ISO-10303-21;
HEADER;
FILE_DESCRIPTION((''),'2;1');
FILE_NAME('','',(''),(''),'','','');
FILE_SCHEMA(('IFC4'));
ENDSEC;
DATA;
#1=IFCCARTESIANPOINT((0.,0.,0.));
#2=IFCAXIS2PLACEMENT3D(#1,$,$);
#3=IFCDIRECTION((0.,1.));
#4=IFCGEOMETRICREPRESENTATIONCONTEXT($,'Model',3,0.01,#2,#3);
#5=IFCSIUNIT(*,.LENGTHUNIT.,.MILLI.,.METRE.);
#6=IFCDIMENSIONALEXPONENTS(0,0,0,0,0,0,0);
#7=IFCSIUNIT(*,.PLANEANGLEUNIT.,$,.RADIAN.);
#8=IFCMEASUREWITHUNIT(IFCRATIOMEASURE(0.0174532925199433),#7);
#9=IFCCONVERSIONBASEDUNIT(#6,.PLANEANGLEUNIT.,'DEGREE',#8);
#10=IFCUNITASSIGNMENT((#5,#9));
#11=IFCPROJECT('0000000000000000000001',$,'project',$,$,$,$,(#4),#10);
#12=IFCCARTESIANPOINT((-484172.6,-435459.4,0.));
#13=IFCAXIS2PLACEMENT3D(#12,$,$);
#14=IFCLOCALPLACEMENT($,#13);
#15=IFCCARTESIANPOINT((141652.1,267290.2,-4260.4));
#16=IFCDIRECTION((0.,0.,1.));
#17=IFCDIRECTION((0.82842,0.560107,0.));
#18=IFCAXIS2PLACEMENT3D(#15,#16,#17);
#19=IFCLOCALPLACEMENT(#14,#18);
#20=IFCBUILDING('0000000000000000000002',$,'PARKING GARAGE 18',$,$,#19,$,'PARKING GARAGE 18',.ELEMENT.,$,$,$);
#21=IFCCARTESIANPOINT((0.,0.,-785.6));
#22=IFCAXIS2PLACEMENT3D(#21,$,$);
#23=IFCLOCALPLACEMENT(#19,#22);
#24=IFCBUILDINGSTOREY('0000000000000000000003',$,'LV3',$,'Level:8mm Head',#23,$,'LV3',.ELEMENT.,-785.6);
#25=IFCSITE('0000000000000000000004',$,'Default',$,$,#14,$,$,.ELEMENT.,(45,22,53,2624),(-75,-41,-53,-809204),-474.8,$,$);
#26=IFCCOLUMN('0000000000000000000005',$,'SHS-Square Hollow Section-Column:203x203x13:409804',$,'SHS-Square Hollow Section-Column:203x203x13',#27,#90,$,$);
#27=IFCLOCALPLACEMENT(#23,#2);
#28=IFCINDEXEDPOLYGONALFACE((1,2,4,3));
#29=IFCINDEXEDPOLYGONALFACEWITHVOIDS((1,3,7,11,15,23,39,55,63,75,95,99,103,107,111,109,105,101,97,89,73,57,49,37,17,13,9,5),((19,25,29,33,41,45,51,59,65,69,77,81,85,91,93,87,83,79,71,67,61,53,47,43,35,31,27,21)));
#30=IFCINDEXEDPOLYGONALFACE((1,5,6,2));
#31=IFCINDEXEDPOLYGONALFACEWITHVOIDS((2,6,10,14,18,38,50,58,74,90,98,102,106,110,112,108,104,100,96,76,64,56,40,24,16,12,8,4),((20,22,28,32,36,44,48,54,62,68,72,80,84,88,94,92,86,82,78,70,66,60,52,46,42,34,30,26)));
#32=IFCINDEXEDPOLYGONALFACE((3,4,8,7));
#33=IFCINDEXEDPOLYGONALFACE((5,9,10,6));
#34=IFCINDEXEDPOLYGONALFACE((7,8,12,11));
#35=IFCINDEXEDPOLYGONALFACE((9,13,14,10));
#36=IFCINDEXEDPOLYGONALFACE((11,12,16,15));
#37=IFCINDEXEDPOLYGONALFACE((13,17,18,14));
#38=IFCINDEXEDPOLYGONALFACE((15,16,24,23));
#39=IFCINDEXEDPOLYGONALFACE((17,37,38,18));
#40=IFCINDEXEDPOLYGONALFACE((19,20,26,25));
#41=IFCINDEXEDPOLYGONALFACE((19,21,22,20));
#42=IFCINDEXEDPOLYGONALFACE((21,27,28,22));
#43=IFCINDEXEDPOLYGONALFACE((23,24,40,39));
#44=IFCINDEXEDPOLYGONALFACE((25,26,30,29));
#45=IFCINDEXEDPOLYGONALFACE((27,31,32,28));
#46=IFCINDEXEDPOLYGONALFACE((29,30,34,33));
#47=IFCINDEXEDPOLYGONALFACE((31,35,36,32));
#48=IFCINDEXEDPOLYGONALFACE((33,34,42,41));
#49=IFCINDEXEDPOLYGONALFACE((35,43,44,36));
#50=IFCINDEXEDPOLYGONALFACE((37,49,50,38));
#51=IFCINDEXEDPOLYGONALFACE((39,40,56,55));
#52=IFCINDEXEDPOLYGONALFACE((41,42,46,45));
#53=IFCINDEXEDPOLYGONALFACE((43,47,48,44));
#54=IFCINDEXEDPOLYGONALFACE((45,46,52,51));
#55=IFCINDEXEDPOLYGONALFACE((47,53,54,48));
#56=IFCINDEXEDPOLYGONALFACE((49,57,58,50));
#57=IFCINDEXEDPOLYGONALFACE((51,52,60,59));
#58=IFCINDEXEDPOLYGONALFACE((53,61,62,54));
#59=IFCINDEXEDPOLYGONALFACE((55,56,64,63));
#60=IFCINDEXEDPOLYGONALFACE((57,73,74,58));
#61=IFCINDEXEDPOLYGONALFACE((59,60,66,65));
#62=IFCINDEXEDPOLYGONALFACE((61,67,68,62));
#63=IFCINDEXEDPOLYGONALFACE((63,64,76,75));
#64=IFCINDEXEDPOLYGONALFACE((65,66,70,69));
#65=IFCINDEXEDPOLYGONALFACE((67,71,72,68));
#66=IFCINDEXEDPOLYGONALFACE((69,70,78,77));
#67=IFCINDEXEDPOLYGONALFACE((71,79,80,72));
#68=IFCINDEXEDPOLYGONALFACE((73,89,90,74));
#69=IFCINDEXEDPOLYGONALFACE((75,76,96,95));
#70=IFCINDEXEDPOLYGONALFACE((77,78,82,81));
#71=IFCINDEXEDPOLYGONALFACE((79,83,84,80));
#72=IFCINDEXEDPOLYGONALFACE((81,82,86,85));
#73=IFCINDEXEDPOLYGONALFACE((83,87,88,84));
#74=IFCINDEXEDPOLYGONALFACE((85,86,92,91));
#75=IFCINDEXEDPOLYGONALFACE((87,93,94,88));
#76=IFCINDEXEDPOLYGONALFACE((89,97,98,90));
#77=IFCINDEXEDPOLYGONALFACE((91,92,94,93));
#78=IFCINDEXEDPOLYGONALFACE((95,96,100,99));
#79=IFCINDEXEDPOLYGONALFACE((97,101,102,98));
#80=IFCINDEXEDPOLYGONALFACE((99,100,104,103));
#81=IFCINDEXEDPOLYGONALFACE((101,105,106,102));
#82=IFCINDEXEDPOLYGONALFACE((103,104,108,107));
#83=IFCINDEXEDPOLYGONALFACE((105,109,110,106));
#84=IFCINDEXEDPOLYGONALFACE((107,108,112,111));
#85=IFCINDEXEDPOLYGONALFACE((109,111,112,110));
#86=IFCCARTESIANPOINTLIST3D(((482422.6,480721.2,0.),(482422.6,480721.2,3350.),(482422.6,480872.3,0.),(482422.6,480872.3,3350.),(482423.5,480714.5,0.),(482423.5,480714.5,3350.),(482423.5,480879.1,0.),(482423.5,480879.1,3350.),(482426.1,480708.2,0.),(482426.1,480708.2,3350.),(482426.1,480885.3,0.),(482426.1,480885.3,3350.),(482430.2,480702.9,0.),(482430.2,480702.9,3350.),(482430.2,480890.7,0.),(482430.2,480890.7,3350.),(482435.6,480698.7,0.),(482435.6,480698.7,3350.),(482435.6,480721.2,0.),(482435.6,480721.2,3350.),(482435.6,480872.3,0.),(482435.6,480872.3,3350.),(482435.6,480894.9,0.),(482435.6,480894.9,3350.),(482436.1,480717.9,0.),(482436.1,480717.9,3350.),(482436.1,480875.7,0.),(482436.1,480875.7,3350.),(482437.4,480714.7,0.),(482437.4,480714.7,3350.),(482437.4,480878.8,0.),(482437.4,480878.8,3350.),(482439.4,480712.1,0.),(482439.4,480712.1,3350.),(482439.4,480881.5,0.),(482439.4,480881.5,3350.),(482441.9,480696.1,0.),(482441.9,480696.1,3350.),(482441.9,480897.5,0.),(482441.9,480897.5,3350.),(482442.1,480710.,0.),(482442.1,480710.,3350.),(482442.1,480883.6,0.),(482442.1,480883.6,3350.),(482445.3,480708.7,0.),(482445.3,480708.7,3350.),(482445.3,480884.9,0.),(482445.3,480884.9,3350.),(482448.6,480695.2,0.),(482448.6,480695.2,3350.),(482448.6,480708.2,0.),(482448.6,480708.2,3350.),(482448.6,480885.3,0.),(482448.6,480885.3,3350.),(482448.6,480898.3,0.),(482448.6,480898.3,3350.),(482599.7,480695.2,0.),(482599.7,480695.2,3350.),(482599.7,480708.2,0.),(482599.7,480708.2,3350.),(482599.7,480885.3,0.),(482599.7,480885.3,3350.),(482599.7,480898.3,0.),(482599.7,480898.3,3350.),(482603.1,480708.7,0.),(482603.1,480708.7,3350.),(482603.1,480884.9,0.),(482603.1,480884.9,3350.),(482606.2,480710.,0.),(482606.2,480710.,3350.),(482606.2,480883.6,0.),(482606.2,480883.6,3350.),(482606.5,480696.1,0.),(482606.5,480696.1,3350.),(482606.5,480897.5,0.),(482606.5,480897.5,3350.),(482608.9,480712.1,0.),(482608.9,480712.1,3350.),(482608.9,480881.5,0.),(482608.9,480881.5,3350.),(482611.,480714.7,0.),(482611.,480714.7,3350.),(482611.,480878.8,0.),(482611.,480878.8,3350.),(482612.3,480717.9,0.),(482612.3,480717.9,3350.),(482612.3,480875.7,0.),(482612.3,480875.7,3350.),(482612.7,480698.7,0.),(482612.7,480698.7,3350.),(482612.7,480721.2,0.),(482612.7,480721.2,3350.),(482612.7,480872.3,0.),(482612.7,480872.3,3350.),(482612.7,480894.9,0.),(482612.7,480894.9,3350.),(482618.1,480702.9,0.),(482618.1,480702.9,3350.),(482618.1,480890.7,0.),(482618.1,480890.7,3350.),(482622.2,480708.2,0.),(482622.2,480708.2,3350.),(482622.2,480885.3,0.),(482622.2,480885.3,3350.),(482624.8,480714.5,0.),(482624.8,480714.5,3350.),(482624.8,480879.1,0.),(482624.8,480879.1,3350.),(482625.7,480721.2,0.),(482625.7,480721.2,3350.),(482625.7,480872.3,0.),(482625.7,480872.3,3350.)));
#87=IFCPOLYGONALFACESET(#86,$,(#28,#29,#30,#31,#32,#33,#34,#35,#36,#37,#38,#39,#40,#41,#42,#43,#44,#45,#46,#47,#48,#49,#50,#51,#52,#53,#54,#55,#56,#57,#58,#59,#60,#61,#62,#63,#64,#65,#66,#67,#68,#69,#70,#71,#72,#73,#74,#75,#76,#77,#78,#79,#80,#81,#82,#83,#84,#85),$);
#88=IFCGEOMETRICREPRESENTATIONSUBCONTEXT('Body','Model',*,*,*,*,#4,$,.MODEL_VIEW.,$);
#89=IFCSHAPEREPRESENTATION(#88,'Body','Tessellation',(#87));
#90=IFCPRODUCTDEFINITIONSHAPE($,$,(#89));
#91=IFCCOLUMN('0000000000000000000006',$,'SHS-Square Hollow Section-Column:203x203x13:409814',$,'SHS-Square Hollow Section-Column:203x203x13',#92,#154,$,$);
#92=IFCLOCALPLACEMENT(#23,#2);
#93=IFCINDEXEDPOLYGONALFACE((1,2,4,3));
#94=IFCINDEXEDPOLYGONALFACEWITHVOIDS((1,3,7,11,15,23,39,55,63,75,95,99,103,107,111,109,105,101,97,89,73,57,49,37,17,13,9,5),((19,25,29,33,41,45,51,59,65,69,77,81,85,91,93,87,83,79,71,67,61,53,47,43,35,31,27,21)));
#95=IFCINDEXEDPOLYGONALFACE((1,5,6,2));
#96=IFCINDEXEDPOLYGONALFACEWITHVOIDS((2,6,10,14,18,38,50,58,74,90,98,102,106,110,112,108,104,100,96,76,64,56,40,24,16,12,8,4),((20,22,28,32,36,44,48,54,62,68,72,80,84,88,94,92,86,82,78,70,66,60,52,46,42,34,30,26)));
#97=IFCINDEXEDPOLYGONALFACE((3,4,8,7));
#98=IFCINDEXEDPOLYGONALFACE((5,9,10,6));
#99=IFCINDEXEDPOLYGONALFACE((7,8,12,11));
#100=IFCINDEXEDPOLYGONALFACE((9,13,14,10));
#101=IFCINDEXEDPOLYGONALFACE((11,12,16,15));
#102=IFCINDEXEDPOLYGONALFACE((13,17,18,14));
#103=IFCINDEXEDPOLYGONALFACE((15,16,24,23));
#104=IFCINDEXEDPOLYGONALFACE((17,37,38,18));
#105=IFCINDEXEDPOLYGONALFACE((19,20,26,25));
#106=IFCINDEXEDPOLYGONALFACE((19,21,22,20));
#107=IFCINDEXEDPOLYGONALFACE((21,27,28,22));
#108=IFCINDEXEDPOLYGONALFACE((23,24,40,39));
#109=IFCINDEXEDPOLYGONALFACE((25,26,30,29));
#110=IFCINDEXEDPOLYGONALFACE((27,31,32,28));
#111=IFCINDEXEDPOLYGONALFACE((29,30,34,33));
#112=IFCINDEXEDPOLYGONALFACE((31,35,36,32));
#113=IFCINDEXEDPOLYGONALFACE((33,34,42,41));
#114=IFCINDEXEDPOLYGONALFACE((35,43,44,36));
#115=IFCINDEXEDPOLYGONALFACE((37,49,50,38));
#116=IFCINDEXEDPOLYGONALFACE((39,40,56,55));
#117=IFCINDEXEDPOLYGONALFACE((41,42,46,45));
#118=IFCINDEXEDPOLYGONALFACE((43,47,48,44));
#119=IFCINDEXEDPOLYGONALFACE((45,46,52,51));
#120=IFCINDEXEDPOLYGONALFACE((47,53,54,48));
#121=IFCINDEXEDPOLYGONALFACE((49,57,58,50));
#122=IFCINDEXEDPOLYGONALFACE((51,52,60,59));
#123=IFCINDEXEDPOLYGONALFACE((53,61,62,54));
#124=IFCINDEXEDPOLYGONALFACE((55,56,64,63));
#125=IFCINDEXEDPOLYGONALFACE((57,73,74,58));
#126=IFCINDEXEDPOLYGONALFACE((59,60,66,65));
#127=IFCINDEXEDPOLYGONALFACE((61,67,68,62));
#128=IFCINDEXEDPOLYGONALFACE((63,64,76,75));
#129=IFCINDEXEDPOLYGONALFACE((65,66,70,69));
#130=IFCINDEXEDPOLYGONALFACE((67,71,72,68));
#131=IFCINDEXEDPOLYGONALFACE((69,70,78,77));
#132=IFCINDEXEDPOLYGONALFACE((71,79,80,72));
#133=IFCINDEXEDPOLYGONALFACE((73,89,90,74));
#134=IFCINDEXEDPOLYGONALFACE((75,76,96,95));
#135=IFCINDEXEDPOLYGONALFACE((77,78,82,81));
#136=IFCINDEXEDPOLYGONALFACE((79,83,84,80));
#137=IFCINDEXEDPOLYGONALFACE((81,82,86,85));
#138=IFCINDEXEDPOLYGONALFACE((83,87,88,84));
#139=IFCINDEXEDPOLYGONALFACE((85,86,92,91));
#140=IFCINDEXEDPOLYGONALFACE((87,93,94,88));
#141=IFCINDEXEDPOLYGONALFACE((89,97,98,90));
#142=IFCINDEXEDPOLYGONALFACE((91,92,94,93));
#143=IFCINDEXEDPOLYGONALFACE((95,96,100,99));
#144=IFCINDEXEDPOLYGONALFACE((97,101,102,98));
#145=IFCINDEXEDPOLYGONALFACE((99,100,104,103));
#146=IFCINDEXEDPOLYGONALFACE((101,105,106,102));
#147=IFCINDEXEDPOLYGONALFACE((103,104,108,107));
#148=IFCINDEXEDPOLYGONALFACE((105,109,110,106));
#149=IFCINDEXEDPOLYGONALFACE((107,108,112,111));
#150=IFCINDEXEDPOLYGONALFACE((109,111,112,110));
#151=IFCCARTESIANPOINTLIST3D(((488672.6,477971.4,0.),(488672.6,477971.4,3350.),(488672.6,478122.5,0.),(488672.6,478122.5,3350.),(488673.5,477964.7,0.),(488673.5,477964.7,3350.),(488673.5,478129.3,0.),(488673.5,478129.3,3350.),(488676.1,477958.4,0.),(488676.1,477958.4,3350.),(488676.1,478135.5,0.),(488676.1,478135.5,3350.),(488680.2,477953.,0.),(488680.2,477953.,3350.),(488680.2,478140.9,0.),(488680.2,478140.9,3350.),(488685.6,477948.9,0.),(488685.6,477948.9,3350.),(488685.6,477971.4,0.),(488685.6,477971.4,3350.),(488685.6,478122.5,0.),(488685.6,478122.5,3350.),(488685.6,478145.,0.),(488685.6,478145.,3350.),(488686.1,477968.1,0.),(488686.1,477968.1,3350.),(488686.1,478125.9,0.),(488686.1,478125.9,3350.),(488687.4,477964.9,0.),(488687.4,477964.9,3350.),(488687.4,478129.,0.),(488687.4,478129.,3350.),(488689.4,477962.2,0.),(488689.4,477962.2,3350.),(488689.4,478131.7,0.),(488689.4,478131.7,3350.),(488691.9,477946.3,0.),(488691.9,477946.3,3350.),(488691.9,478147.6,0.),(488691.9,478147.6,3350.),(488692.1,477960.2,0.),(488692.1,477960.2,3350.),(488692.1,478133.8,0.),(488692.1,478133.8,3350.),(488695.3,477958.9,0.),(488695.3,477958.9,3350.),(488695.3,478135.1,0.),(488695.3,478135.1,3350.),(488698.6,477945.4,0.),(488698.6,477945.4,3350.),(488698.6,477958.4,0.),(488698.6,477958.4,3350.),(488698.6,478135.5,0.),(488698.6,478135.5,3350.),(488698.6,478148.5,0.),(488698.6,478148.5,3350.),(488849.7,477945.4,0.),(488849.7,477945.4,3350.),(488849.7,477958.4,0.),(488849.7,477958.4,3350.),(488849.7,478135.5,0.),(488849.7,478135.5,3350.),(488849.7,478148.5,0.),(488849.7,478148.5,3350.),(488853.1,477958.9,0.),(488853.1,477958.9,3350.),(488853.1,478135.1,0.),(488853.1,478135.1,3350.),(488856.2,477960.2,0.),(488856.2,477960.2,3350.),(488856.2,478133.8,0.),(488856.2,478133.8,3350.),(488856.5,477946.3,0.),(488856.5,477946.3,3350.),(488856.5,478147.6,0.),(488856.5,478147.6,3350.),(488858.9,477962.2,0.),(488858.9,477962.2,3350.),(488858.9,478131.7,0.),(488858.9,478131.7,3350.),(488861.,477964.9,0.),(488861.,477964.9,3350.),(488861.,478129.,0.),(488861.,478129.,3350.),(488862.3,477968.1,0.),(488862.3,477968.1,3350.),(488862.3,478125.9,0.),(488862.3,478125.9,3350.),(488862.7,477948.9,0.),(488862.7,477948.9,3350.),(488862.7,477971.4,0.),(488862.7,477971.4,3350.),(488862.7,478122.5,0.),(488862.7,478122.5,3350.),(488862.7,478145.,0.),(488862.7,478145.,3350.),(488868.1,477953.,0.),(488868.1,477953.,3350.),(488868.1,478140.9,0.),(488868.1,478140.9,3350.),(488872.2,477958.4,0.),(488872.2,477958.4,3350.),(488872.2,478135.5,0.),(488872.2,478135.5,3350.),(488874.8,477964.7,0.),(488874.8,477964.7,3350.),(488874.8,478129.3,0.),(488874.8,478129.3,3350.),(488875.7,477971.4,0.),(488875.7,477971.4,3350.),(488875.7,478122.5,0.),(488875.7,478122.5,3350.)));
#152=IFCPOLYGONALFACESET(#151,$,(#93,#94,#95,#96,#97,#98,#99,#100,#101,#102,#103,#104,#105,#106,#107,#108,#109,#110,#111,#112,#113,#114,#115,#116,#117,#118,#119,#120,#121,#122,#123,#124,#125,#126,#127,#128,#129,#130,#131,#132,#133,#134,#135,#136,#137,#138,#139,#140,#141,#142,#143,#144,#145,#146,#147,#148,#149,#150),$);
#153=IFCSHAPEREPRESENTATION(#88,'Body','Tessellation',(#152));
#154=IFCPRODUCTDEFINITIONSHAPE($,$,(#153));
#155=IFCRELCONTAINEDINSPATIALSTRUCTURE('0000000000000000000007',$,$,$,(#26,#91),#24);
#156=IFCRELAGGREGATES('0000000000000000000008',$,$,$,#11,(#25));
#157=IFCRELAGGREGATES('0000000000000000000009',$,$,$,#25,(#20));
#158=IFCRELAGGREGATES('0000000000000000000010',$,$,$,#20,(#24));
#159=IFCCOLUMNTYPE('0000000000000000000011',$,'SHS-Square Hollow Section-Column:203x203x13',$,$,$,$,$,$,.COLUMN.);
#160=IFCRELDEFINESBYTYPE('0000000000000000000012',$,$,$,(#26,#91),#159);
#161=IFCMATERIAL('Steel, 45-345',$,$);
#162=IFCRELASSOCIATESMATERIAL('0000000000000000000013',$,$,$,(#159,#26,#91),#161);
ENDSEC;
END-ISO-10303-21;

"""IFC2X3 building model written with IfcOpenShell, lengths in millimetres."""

from ifc_helpers import new_model, entity, si_unit, converted_unit, direction, frame, frame_2d, origin, place, context, subcontext, project, spatial, polyline, circle_curve, parameter, trimmed, segment, composite_curve, outline, extrude, source, transform, mapped, material, type_object, type_shapes, element, save


model = new_model("IFC2X3")

# Units and contexts
model_context = context("Model", 3, precision=0.01, world=origin(), true_north=direction((0.0, 1.0)))
body_context = subcontext(model_context, "Body", "Model", "MODEL_VIEW")
ifc_project = project(units=[si_unit("LENGTHUNIT", "METRE", prefix="MILLI"), converted_unit("PLANEANGLEUNIT", "DEGREE", entity("IfcRatioMeasure", 0.0174532925199433), si_unit("PLANEANGLEUNIT", "RADIAN"), dimensions=[0, 0, 0, 0, 0, 0, 0])], contexts=[model_context])

# Site, building, storey
site_placement = place(None, frame((-484172.6, -435459.4, 0.0)))
site = spatial("IfcSite", under=ifc_project, at=site_placement, Name="Default", CompositionType="ELEMENT", RefLatitude=(45, 22, 53, 2624), RefLongitude=(-75, -41, -53, -809204), RefElevation=-474.8)
building_placement = place(site_placement, frame((141652.1, 267290.2, -4260.4), z_axis=(0.0, 0.0, 1.0), x_axis=(0.82842, 0.560107, 0.0)))
building = spatial("IfcBuilding", under=site, at=building_placement, Name="PARKING GARAGE 18", LongName="PARKING GARAGE 18", CompositionType="ELEMENT")
storey_placement = place(building_placement, frame((0.0, 0.0, -785.6)))
storey = spatial("IfcBuildingStorey", under=building, at=storey_placement, Name="LV3", ObjectType="Level:8mm Head", LongName="LV3", CompositionType="ELEMENT", Elevation=-785.6)

# Columns
ifc_material_1 = material(Name="Steel, 45-345")
column_type_1 = type_object("IfcColumnType", Name="SHS-Square Hollow Section-Column:203x203x13", PredefinedType="COLUMN", material=ifc_material_1)
shared_shape_1 = source(origin(), body_context, "Body", "SweptSolid", [
    extrude(outline(composite_curve([segment(polyline([(-75.6, -101.5), (75.6, -101.5)]), True, "CONTINUOUS"), segment(trimmed(circle_curve(frame_2d((75.6, -75.6), x_axis=(-1.0, 0.0)), 26.0), [parameter(90.0)], [parameter(180.0)], True, "PARAMETER"), True, "CONTINUOUS"), segment(polyline([(101.5, -75.6), (101.5, 75.6)]), True, "CONTINUOUS"), segment(trimmed(circle_curve(frame_2d((75.5, 75.6), x_axis=(-1.0, 0.0)), 26.0), [parameter(180.0)], [parameter(270.0)], True, "PARAMETER"), True, "CONTINUOUS"), segment(polyline([(75.5, 101.6), (-75.5, 101.6)]), True, "CONTINUOUS"), segment(trimmed(circle_curve(frame_2d((-75.5, 75.5), x_axis=(-1.0, 0.0)), 26.0), [parameter(270.0)], [parameter(360.0)], True, "PARAMETER"), True, "CONTINUOUS"), segment(polyline([(-101.5, 75.5), (-101.5, -75.6)]), True, "CONTINUOUS"), segment(trimmed(circle_curve(frame_2d((-75.6, -75.6), x_axis=(-1.0, 0.0)), 26.0), [parameter(360.0)], [parameter(90.0)], True, "PARAMETER"), True, "CONTINUOUS")], self_intersect=False), holes=[composite_curve([segment(trimmed(circle_curve(frame_2d((-75.6, -75.6), x_axis=(-1.0, 0.0)), 13.0), [parameter(0.0)], [parameter(90.0)], True, "PARAMETER"), False, "CONTINUOUS"), segment(polyline([(-88.5, -75.6), (-88.5, 75.6)]), True, "CONTINUOUS"), segment(trimmed(circle_curve(frame_2d((-75.6, 75.6), x_axis=(-1.0, 0.0)), 13.0), [parameter(270.0)], [parameter(0.0)], True, "PARAMETER"), False, "CONTINUOUS"), segment(polyline([(-75.6, 88.6), (75.5, 88.6)]), True, "CONTINUOUS"), segment(trimmed(circle_curve(frame_2d((75.5, 75.5), x_axis=(-1.0, 0.0)), 13.0), [parameter(180.0)], [parameter(270.0)], True, "PARAMETER"), False, "CONTINUOUS"), segment(polyline([(88.6, 75.5), (88.6, -75.5)]), True, "CONTINUOUS"), segment(trimmed(circle_curve(frame_2d((75.6, -75.5), x_axis=(-1.0, 0.0)), 13.0), [parameter(90.0)], [parameter(180.0)], True, "PARAMETER"), False, "CONTINUOUS"), segment(polyline([(75.6, -88.5), (-75.6, -88.5)]), True, "CONTINUOUS")], self_intersect=False)]), frame((0.0, 0.0, -785.6), z_axis=(0.0, 0.0, 1.0), x_axis=(-1.0, 0.0, 0.0)), (0.0, 0.0, 1.0), 3350.0),
])
type_shapes(column_type_1, [shared_shape_1])
for number, where, name in (
    (1, (482524.2, 480796.8, 785.6), "SHS-Square Hollow Section-Column:203x203x13:409804"),
    (2, (488774.2, 478047.0, 785.6), "SHS-Square Hollow Section-Column:203x203x13:409814"),
):
    element("IfcColumn", number, at=place(storey_placement, frame(where)), inside=storey, type_object=column_type_1, material=ifc_material_1, Name=name, ObjectType="SHS-Square Hollow Section-Column:203x203x13", context=body_context, shape_type="MappedRepresentation", body=[
        mapped(shared_shape_1, transform((0.0, 0.0, 0.0), scale=1.0)),
    ])

save(model, "model.ifc")
